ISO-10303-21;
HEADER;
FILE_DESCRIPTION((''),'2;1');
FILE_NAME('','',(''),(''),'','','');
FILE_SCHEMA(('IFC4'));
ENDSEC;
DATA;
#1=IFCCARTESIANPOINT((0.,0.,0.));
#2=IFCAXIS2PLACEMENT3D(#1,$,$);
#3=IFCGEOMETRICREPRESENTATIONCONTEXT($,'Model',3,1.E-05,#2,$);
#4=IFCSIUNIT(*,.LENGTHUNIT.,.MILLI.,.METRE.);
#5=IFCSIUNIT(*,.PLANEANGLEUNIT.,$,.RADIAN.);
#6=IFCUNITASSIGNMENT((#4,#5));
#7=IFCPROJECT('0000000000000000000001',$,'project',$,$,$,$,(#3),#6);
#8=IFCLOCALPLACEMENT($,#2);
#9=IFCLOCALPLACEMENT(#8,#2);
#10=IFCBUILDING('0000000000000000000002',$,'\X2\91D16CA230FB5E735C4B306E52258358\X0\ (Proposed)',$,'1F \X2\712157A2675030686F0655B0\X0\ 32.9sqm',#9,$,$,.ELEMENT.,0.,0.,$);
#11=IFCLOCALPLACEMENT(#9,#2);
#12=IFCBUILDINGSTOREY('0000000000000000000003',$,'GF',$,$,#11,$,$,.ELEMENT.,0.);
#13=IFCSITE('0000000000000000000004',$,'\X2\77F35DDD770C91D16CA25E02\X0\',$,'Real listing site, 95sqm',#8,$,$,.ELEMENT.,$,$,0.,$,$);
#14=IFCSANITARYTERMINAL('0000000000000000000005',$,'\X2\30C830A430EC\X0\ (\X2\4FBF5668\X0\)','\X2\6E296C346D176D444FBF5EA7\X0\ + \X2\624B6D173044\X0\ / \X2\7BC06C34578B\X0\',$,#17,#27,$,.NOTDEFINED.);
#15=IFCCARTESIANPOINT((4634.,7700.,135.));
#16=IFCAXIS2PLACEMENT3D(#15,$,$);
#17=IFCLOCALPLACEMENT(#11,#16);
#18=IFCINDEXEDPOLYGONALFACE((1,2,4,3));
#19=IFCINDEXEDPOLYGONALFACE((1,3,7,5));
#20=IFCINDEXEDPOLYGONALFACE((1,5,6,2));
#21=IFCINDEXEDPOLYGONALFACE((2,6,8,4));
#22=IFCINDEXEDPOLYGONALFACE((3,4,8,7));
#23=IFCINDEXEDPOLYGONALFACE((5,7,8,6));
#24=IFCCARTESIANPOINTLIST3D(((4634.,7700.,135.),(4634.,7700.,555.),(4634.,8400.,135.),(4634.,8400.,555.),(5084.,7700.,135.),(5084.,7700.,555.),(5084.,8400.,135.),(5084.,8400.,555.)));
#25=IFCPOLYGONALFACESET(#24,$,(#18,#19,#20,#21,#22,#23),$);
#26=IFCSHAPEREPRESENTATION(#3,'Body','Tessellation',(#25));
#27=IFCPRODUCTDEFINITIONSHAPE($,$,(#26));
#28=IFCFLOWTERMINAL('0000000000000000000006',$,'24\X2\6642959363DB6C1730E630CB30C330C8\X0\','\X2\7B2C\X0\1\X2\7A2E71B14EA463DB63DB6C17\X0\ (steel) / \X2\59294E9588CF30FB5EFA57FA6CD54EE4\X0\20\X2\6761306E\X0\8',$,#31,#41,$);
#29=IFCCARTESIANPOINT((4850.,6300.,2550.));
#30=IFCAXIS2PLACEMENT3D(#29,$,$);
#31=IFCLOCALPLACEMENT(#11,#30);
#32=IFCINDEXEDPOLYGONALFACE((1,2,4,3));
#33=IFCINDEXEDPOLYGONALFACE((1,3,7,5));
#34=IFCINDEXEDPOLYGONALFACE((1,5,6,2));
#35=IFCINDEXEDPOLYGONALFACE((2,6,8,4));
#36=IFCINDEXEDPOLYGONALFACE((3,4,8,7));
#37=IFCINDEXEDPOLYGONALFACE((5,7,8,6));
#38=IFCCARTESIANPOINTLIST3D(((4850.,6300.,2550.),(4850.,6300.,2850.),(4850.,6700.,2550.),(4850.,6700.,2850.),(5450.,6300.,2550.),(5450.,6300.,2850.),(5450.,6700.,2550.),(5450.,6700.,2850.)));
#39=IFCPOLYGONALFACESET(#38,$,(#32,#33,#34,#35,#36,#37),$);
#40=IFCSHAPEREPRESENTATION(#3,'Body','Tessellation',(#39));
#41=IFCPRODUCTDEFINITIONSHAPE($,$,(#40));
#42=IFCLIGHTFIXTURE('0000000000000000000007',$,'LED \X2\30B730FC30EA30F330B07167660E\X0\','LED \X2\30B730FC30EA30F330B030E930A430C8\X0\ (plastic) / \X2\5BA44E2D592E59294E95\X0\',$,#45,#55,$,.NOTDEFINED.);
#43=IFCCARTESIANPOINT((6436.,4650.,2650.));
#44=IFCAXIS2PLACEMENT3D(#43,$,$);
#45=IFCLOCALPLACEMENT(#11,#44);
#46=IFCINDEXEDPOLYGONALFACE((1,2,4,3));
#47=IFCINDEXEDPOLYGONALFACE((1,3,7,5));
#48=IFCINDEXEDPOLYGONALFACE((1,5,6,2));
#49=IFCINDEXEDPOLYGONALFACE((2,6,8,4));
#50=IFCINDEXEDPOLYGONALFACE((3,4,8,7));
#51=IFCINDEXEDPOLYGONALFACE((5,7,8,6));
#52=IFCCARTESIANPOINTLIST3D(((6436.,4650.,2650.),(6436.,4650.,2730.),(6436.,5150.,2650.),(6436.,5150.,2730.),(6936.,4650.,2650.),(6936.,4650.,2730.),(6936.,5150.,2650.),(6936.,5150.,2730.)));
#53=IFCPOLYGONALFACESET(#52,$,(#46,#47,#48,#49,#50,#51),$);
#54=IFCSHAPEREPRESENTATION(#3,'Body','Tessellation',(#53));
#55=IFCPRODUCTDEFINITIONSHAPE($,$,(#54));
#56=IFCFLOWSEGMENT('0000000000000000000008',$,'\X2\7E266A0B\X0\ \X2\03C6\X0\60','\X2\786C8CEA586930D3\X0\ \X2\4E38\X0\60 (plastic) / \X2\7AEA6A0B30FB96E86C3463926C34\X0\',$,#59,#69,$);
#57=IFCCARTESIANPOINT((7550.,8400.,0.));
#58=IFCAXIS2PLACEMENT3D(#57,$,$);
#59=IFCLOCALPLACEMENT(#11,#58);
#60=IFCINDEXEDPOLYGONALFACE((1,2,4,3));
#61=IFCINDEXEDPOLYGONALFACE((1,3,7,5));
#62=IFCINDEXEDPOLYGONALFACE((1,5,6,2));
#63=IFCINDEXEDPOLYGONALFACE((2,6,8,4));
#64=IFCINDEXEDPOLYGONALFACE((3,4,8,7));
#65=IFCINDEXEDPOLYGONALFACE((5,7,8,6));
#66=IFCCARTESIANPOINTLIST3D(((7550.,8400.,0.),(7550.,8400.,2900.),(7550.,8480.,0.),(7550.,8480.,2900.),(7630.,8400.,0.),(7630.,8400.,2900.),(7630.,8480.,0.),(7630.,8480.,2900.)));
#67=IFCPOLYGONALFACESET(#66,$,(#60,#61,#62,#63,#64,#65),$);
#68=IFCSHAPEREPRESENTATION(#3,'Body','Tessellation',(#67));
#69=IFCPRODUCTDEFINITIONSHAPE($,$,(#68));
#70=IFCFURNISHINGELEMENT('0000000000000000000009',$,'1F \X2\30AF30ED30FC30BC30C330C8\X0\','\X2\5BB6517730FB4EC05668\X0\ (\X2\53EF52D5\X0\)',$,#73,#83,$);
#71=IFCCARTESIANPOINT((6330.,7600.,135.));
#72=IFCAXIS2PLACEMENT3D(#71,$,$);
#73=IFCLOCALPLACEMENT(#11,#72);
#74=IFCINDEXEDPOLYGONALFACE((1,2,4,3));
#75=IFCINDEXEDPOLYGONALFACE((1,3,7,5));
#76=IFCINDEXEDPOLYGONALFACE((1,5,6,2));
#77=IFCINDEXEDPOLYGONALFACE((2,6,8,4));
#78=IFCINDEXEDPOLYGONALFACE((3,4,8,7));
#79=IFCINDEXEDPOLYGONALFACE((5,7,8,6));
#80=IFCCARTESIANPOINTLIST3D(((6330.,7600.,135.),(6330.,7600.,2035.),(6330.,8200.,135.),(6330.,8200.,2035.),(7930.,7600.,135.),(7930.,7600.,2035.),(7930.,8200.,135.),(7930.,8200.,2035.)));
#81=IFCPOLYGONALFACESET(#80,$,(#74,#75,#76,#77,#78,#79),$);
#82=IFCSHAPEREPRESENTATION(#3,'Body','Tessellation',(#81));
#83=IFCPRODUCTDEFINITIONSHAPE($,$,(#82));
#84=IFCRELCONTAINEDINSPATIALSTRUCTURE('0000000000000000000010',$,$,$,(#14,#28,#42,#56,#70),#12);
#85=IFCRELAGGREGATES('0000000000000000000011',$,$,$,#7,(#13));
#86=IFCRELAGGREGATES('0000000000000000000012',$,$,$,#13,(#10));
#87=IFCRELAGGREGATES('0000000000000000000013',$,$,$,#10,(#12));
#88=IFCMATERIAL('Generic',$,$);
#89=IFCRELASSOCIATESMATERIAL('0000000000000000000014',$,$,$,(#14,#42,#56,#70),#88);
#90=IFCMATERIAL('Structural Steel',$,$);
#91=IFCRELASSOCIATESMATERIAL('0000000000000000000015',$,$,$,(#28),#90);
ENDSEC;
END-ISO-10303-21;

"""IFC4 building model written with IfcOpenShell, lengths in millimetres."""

from ifc_helpers import new_model, si_unit, frame, frame_2d, origin, place, context, project, spatial, rectangle, extrude, material, element, save


model = new_model("IFC4")

# Units and contexts
model_context = context("Model", 3, precision=1e-05, world=origin())
ifc_project = project(units=[si_unit("LENGTHUNIT", "METRE", prefix="MILLI"), si_unit("PLANEANGLEUNIT", "RADIAN")], contexts=[model_context])

# Site, building, storey
site_placement = place(None, origin())
site = spatial("IfcSite", under=ifc_project, at=site_placement, Name="石川県金沢市", ObjectType="Real listing site, 95sqm", CompositionType="ELEMENT", RefElevation=0.0)
building_placement = place(site_placement, origin())
building = spatial("IfcBuilding", under=site, at=building_placement, Name="金沢・平屋の別荘 (Proposed)", ObjectType="1F 無垢材と漆喰 32.9sqm", CompositionType="ELEMENT", ElevationOfRefHeight=0.0, ElevationOfTerrain=0.0)
storey_placement = place(building_placement, origin())
storey = spatial("IfcBuildingStorey", under=building, at=storey_placement, Name="GF", CompositionType="ELEMENT", Elevation=0.0)

# Shared definitions
ifc_material_1 = material(Name="Generic")

# Sanitary terminal
sanitary_terminal_1_placement = place(storey_placement, frame((4634.0, 7700.0, 135.0)))
element("IfcSanitaryTerminal", 1, at=sanitary_terminal_1_placement, inside=storey, material=ifc_material_1, Name="トイレ (便器)", Description="温水洗浄便座 + 手洗い / 節水型", PredefinedType="NOTDEFINED", context=model_context, shape_type="SweptSolid", body=[
    extrude(rectangle(XDim=450.0, YDim=700.0, at=frame_2d((225.0, 350.0))), frame((4634.0, 7700.0, 135.0)), (0.0, 0.0, 1.0), 420.0),
])

# Flow terminal
ifc_material_2 = material(Name="Structural Steel")
flow_terminal_placement = place(storey_placement, frame((4850.0, 6300.0, 2550.0)))
element("IfcFlowTerminal", 2, at=flow_terminal_placement, inside=storey, material=ifc_material_2, Name="24時間換気ユニット", Description="第1種熱交換換気 (steel) / 天井裏・建基法令20条の8", context=model_context, shape_type="SweptSolid", body=[
    extrude(rectangle(XDim=600.0, YDim=400.0, at=frame_2d((300.0, 200.0))), frame((4850.0, 6300.0, 2550.0)), (0.0, 0.0, 1.0), 300.0),
])

# Light fixture
light_fixture_placement = place(storey_placement, frame((6436.0, 4650.0, 2650.0)))
element("IfcLightFixture", 3, at=light_fixture_placement, inside=storey, material=ifc_material_1, Name="LED シーリング照明", Description="LED シーリングライト (plastic) / 室中央天井", PredefinedType="NOTDEFINED", context=model_context, shape_type="SweptSolid", body=[
    extrude(rectangle(XDim=500.0, YDim=500.0, at=frame_2d((250.0, 250.0))), frame((6436.0, 4650.0, 2650.0)), (0.0, 0.0, 1.0), 80.0),
])

# Flow segment
flow_segment_placement = place(storey_placement, frame((7550.0, 8400.0, 0.0)))
element("IfcFlowSegment", 4, at=flow_segment_placement, inside=storey, material=ifc_material_1, Name="縦樋 φ60", Description="硬質塩ビ 丸60 (plastic) / 竪樋・雨水排水", context=model_context, shape_type="SweptSolid", body=[
    extrude(rectangle(XDim=80.0, YDim=80.0, at=frame_2d((40.0, 40.0))), frame((7550.0, 8400.0, 0.0)), (0.0, 0.0, 1.0), 2900.0),
])

# Furnishing element
furnishing_placement = place(storey_placement, frame((6330.0, 7600.0, 135.0)))
element("IfcFurnishingElement", 5, at=furnishing_placement, inside=storey, material=ifc_material_1, Name="1F クローゼット", Description="家具・什器 (可動)", context=model_context, shape_type="SweptSolid", body=[
    extrude(rectangle(XDim=1600.0, YDim=600.0, at=frame_2d((800.0, 300.0))), frame((6330.0, 7600.0, 135.0)), (0.0, 0.0, 1.0), 1900.0),
])

save(model, "model.ifc")
